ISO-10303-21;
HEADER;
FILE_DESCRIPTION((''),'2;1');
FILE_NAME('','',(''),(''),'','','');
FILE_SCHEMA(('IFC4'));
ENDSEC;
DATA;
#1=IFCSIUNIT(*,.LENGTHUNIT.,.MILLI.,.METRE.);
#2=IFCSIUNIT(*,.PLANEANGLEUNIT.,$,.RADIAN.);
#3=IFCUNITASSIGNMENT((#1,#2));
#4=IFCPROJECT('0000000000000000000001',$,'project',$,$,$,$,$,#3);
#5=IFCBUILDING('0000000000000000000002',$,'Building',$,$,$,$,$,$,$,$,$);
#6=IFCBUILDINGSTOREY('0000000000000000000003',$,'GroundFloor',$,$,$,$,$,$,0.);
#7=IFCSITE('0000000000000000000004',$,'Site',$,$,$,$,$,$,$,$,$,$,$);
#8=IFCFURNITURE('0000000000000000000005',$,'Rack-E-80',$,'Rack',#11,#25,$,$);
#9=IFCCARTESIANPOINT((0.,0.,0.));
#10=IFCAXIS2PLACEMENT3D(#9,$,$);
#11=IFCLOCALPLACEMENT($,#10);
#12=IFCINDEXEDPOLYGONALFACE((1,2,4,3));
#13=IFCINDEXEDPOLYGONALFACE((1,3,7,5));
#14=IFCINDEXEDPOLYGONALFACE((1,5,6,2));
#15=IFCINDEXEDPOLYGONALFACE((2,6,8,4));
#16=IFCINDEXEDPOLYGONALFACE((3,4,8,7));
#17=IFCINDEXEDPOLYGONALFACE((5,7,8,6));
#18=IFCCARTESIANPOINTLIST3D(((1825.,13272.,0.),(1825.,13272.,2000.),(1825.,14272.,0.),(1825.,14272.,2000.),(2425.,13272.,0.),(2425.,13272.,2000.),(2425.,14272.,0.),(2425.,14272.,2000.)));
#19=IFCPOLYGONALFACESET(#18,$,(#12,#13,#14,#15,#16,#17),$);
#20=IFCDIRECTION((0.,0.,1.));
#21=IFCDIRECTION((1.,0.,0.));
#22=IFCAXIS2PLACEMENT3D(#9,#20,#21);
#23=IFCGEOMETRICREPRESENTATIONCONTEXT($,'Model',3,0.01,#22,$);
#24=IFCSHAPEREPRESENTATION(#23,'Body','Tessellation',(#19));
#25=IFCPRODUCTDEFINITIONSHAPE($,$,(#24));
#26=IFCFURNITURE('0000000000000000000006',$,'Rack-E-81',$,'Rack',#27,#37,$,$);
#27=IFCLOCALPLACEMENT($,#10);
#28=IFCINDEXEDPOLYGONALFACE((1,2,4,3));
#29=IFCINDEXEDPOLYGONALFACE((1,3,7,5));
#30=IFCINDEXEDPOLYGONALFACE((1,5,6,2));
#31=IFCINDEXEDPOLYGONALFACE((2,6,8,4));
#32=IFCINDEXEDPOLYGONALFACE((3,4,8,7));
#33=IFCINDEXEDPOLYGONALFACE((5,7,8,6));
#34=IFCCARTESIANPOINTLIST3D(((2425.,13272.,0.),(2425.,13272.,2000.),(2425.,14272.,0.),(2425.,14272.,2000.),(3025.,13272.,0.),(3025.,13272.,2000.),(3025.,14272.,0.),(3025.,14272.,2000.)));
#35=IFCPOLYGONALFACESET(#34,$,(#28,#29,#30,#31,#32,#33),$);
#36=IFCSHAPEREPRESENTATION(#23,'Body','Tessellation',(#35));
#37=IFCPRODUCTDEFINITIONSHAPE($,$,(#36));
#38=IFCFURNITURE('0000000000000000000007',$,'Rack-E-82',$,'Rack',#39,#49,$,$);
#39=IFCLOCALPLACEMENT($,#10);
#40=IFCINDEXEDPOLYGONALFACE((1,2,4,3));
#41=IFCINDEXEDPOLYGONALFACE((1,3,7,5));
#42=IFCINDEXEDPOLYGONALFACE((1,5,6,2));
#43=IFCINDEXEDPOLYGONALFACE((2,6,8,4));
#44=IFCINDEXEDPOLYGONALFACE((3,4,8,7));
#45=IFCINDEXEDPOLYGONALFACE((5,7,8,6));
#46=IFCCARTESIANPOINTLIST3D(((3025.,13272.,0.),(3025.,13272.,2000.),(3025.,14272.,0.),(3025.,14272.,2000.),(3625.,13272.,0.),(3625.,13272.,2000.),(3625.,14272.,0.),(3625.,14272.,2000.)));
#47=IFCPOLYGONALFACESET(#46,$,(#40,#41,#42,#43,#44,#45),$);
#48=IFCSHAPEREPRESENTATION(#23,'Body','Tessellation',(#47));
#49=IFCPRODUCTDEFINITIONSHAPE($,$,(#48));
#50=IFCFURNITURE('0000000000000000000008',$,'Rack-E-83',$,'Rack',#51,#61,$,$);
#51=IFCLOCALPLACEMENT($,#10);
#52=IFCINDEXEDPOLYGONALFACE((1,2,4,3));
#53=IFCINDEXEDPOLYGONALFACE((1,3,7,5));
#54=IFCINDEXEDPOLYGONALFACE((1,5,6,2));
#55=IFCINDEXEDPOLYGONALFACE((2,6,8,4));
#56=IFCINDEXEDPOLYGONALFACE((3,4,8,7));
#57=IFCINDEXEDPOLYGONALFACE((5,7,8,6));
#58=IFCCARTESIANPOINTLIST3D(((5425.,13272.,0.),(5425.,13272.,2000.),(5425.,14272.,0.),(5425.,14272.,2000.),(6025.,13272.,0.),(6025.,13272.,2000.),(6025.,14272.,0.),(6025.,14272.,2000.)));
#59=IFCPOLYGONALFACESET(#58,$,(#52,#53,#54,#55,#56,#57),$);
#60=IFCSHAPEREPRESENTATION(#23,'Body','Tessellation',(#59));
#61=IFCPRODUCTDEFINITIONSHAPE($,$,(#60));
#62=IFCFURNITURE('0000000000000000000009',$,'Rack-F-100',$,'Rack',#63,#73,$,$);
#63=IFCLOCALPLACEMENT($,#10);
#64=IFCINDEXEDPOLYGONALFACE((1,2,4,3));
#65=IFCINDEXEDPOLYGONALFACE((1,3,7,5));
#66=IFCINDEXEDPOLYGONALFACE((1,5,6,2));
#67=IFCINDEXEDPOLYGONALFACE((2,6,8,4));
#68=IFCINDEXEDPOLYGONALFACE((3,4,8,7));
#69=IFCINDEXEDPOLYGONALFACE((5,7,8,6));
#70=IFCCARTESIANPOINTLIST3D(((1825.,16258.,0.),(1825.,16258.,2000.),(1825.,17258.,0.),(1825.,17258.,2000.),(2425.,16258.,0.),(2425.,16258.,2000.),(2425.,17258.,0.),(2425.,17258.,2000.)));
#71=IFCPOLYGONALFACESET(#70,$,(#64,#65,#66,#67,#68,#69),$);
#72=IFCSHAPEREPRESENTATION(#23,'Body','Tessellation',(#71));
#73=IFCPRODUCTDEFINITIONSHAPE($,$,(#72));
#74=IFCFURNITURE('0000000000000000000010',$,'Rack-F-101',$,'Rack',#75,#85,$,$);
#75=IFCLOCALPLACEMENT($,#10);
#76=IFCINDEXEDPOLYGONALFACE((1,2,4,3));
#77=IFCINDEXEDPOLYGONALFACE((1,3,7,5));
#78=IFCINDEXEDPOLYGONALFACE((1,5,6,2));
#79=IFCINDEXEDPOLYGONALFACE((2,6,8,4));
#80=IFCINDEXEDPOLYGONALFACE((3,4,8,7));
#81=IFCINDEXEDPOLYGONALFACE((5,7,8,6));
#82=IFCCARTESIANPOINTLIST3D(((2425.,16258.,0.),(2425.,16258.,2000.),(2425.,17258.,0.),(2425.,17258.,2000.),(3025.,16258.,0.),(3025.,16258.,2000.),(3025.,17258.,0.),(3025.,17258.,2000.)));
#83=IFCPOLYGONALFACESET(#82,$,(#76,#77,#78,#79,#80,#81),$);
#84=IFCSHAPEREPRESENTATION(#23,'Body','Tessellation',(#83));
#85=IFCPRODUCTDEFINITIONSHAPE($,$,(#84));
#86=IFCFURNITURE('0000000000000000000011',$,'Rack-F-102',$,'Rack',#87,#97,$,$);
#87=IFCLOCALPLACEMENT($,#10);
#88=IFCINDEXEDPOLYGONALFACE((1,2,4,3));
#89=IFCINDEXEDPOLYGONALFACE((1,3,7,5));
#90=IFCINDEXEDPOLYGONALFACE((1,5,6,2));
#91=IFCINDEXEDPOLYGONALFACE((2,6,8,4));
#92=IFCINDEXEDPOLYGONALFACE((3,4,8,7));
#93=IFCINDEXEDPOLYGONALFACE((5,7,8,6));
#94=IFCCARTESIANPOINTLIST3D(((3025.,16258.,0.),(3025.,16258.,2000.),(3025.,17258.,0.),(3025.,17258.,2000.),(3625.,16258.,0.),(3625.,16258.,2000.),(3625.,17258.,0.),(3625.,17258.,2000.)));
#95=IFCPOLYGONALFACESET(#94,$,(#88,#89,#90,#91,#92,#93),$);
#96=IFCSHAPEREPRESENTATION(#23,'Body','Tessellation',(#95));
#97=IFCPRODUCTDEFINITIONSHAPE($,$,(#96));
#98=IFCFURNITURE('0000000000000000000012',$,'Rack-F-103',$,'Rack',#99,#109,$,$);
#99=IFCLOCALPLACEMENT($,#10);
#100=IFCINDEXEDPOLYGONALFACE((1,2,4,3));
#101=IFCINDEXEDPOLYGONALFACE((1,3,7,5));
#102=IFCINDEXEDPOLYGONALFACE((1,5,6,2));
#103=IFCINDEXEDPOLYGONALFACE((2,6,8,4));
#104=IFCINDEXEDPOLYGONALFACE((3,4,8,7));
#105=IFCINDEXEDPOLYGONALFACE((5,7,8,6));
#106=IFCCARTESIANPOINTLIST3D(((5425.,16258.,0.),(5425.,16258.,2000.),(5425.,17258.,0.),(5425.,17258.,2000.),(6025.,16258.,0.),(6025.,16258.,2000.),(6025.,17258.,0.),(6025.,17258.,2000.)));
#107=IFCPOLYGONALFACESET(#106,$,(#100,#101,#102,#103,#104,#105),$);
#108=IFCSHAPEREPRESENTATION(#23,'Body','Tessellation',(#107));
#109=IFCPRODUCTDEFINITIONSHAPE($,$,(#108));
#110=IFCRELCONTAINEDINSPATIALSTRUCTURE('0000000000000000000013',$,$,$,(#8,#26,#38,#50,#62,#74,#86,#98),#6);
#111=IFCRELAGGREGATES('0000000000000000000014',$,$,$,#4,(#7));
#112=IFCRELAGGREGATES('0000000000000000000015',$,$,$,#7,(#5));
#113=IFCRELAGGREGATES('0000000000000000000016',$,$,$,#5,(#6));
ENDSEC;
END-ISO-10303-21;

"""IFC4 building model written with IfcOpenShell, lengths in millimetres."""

from ifc_helpers import new_model, si_unit, frame, origin, origin_with_axes, origin_2d, place, context, project, spatial, rectangle, extrude, element, save


model = new_model("IFC4")

# Units and contexts
model_context = context("Model", 3, precision=0.01, world=origin_with_axes())
ifc_project = project(units=[si_unit("LENGTHUNIT", "METRE", prefix="MILLI"), si_unit("PLANEANGLEUNIT", "RADIAN")])

# Site, building, storey
site = spatial("IfcSite", under=ifc_project, Name="Site")
building = spatial("IfcBuilding", under=site, Name="Building")
storey = spatial("IfcBuildingStorey", under=building, Name="GroundFloor", Elevation=0.0)

# Furniture
for number, where, z_axis, x_axis, name in (
    (1, (2125.0, 13772.0, 0.0), (0.0, 0.0, 1.0), (1.0, 0.0, 0.0), "Rack-E-80"),
    (2, (2725.0, 13772.0, 0.0), (0.0, 0.0, 1.0), (1.0, 0.0, 0.0), "Rack-E-81"),
    (3, (3325.0, 13772.0, 0.0), (0.0, 0.0, 1.0), (1.0, 0.0, 0.0), "Rack-E-82"),
    (4, (5725.0, 13772.0, 0.0), (0.0, 0.0, 1.0), (1.0, 0.0, 0.0), "Rack-E-83"),
    (5, (2125.0, 16758.0, 0.0), (0.0, 0.0, 1.0), (1.0, 0.0, 0.0), "Rack-F-100"),
    (6, (2725.0, 16758.0, 0.0), (0.0, 0.0, 1.0), (1.0, 0.0, 0.0), "Rack-F-101"),
    (7, (3325.0, 16758.0, 0.0), (0.0, 0.0, 1.0), (1.0, 0.0, 0.0), "Rack-F-102"),
    (8, (5725.0, 16758.0, 0.0), (0.0, 0.0, 1.0), (1.0, 0.0, 0.0), "Rack-F-103"),
):
    element("IfcFurniture", number, at=place(None, frame(where, z_axis=z_axis, x_axis=x_axis)), inside=storey, Name=name, ObjectType="Rack", context=model_context, shape_type="SweptSolid", body=[
        extrude(rectangle(XDim=600.0, YDim=1000.0, at=origin_2d()), origin(), (0.0, 0.0, 1.0), 2000.0),
    ])

save(model, "model.ifc")
